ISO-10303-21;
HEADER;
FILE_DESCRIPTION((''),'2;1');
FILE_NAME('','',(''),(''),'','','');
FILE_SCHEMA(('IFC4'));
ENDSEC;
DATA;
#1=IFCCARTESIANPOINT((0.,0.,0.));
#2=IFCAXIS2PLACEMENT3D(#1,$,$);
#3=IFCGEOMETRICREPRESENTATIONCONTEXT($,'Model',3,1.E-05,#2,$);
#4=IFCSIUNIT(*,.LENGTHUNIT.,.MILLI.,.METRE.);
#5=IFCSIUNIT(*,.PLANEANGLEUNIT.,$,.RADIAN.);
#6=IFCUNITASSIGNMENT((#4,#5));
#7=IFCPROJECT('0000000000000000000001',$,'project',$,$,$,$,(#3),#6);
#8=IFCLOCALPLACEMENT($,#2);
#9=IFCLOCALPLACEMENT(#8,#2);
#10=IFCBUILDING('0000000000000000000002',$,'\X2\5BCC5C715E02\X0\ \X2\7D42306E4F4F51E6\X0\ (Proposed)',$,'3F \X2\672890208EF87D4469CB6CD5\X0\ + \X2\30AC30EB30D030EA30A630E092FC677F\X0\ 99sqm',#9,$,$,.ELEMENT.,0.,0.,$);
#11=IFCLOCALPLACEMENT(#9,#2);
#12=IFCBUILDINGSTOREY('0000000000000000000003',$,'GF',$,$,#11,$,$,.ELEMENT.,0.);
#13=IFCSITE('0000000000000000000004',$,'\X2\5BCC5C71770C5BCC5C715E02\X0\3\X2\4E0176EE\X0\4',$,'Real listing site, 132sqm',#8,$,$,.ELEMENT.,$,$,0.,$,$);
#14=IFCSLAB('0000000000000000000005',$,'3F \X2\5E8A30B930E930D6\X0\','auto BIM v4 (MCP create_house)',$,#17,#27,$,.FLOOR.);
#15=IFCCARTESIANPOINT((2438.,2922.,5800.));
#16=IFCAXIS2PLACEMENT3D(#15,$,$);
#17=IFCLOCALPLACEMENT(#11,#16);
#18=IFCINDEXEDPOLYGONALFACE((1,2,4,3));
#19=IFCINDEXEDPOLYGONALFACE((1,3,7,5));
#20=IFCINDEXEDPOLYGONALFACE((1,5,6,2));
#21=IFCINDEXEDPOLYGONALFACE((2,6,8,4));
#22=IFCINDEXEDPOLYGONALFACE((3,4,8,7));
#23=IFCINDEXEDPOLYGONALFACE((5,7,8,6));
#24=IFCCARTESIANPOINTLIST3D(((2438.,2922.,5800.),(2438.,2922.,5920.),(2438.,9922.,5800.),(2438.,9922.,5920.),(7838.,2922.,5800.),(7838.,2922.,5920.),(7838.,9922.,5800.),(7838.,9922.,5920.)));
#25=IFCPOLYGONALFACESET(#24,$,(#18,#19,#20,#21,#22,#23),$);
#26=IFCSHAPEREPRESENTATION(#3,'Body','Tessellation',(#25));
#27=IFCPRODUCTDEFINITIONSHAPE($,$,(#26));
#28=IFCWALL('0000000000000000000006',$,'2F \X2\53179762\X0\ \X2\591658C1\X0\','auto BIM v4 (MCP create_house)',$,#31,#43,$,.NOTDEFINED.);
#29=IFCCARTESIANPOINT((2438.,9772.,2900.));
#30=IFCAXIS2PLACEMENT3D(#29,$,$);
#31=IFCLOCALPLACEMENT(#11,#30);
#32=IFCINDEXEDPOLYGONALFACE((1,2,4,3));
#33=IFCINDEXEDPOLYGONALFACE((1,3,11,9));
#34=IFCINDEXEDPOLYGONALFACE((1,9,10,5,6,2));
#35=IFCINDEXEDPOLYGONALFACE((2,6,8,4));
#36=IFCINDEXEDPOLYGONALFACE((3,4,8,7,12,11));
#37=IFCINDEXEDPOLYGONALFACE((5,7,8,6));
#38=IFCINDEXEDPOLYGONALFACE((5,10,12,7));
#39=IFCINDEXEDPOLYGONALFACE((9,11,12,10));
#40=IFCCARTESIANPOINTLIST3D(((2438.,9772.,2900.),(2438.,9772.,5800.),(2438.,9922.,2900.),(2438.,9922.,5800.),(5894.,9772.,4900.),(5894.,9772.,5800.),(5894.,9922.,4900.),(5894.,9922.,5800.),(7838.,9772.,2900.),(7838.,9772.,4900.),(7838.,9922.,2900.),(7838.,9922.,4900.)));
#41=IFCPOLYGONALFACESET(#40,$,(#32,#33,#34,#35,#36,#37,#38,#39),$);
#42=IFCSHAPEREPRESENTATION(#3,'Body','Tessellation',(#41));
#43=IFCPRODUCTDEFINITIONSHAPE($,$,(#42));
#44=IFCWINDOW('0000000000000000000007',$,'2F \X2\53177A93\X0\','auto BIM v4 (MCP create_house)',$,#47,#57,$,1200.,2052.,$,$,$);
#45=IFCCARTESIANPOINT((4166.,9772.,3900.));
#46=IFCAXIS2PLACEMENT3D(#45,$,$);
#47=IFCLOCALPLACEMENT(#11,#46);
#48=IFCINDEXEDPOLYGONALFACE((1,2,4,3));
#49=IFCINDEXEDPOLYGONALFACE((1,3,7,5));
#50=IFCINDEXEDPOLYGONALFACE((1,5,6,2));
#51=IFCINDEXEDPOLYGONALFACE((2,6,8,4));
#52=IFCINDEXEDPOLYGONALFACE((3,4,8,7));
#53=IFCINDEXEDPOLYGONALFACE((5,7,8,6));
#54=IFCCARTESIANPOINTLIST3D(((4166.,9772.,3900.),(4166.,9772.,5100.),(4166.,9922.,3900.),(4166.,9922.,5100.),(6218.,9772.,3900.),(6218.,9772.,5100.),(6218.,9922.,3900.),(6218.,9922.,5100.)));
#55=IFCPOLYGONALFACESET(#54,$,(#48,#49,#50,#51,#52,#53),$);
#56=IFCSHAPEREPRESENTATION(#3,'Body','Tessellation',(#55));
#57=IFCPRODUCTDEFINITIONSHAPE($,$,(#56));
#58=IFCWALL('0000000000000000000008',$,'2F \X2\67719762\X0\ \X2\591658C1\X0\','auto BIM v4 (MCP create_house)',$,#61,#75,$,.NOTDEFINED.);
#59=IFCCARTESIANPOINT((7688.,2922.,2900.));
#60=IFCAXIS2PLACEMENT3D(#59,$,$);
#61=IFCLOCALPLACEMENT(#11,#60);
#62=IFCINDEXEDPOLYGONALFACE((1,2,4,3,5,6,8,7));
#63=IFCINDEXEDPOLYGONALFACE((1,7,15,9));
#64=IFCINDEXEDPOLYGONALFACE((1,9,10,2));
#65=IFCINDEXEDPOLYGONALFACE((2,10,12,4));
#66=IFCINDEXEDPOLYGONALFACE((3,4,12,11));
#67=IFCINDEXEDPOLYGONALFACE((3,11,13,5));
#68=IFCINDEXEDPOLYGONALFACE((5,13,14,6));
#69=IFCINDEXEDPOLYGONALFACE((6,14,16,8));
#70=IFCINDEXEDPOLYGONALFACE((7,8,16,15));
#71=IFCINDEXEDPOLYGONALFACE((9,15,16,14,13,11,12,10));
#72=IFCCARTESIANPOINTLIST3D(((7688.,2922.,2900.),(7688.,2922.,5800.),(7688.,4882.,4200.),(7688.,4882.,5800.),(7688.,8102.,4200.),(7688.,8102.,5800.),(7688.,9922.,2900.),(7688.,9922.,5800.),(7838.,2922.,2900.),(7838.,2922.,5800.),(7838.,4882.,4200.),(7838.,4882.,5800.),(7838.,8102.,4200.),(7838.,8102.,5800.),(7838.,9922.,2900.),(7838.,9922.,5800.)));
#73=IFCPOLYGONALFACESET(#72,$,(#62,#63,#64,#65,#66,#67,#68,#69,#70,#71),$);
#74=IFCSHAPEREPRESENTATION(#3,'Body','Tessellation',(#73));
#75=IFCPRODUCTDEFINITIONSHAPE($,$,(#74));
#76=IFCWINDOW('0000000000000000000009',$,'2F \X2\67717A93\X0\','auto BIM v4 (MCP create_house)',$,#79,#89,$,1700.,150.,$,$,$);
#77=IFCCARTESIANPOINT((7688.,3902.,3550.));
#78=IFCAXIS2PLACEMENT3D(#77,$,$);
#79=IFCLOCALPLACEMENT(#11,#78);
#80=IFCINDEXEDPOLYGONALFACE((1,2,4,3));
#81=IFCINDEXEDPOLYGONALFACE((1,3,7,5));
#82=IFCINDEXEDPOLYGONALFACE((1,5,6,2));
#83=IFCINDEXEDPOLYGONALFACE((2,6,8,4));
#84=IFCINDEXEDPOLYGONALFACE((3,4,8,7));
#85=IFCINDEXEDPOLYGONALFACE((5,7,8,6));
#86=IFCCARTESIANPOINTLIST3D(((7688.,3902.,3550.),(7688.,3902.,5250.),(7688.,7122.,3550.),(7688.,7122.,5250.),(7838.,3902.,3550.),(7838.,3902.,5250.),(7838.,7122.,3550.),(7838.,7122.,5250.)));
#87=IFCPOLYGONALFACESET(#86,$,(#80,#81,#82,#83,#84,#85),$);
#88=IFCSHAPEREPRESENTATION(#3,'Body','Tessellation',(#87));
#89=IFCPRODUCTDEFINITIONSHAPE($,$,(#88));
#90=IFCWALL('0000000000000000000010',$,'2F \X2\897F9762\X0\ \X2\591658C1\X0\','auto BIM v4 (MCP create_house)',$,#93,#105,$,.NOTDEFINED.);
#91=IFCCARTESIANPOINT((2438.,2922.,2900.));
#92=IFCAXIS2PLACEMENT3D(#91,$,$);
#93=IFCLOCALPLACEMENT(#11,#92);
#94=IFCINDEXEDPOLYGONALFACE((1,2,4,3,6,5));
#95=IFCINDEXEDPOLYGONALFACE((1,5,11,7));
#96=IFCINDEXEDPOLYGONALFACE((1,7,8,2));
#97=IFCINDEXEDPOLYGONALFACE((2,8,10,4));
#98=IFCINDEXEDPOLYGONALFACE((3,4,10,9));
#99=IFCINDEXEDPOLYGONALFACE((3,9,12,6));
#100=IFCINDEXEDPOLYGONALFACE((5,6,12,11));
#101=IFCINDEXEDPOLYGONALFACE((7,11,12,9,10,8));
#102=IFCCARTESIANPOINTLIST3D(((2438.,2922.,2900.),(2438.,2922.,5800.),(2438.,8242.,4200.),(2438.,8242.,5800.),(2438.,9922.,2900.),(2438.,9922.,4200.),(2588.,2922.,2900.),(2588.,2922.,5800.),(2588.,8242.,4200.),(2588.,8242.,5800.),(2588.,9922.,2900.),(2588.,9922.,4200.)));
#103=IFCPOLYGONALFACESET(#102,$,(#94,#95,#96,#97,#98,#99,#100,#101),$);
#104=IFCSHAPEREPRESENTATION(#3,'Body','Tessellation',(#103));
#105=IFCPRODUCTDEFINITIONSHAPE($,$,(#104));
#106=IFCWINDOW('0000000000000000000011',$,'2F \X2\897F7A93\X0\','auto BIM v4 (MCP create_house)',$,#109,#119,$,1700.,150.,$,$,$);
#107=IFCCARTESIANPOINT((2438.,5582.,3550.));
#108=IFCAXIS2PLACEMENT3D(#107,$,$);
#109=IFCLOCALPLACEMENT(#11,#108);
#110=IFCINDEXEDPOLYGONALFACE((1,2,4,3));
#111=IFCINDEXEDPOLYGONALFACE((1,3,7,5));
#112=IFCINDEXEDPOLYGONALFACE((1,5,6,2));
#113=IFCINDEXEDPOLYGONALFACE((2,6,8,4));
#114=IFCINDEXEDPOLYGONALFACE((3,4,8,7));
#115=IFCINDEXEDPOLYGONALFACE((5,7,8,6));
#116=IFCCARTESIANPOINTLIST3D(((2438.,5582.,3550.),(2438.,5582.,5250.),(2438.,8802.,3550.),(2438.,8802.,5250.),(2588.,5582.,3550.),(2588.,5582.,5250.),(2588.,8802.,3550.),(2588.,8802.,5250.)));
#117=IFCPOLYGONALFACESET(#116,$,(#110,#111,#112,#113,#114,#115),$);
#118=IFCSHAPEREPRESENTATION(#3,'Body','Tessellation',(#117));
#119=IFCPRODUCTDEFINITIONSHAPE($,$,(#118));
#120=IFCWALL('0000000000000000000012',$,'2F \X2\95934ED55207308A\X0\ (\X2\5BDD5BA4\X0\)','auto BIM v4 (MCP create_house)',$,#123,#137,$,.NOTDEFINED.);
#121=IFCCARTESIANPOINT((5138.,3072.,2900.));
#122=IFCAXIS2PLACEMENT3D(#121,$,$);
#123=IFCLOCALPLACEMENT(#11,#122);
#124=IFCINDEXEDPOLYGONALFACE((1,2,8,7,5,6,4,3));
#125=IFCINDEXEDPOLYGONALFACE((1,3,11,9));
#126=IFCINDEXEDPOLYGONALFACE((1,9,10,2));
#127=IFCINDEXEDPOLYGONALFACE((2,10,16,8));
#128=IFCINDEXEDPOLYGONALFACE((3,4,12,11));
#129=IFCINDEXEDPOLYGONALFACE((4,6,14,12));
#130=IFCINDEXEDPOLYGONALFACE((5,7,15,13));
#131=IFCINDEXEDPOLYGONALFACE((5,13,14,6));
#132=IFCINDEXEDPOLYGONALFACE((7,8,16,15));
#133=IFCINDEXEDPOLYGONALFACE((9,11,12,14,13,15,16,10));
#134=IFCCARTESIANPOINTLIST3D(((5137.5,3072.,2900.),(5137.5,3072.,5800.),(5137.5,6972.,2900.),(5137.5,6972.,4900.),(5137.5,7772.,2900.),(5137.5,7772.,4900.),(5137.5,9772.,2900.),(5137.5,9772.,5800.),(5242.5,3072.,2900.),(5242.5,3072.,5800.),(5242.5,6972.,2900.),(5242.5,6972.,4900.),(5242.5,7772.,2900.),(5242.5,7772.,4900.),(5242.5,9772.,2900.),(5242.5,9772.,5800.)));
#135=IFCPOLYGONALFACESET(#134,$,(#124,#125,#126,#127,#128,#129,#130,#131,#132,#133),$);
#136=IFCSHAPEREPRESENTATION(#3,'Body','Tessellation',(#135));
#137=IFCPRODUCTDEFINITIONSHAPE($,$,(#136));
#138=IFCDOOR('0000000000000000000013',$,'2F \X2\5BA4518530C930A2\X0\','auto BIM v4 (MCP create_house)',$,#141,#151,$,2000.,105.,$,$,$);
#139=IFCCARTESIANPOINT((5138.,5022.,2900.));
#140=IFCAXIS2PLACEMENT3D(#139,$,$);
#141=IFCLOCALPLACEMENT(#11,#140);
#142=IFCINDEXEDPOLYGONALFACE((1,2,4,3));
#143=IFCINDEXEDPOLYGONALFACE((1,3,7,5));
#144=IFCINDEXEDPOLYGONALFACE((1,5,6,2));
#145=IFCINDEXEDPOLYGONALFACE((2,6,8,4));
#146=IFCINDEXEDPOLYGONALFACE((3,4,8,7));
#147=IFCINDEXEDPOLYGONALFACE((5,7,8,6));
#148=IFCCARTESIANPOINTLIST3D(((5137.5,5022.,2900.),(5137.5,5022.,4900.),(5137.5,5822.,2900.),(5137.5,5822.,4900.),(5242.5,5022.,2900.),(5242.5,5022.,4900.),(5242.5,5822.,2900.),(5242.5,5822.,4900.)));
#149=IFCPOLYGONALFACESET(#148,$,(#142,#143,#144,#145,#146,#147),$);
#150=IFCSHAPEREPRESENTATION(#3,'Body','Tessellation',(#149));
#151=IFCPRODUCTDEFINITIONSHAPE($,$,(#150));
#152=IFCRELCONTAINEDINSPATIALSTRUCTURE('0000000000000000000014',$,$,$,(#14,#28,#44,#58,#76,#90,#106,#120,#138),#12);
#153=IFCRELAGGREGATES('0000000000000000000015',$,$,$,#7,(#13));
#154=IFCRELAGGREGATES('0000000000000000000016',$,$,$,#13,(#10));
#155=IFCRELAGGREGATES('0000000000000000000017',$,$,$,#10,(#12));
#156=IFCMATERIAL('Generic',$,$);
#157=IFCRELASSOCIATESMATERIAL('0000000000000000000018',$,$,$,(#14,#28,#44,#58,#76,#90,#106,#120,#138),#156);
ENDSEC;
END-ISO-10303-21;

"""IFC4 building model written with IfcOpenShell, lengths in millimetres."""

from ifc_helpers import new_model, si_unit, frame, frame_2d, origin, place, context, project, spatial, rectangle, extrude, material, element, fill, save


model = new_model("IFC4")

# Units and contexts
model_context = context("Model", 3, precision=1e-05, world=origin())
ifc_project = project(units=[si_unit("LENGTHUNIT", "METRE", prefix="MILLI"), si_unit("PLANEANGLEUNIT", "RADIAN")], contexts=[model_context])

# Site, building, storey
site_placement = place(None, origin())
site = spatial("IfcSite", under=ifc_project, at=site_placement, Name="富山県富山市3丁目4", ObjectType="Real listing site, 132sqm", CompositionType="ELEMENT", RefElevation=0.0)
building_placement = place(site_placement, origin())
building = spatial("IfcBuilding", under=site, at=building_placement, Name="富山市 終の住処 (Proposed)", ObjectType="3F 木造軸組構法 + ガルバリウム鋼板 99sqm", CompositionType="ELEMENT", ElevationOfRefHeight=0.0, ElevationOfTerrain=0.0)
storey_placement = place(building_placement, origin())
storey = spatial("IfcBuildingStorey", under=building, at=storey_placement, Name="GF", CompositionType="ELEMENT", Elevation=0.0)

# Slab
ifc_material = material(Name="Generic")
slab_placement = place(storey_placement, frame((2438.0, 2922.0, 5800.0)))
element("IfcSlab", 1, at=slab_placement, inside=storey, material=ifc_material, Name="3F 床スラブ", Description="auto BIM v4 (MCP create_house)", PredefinedType="FLOOR", context=model_context, shape_type="SweptSolid", body=[
    extrude(rectangle(XDim=5400.0, YDim=7000.0, at=frame_2d((2700.0, 3500.0))), frame((2438.0, 2922.0, 5800.0)), (0.0, 0.0, 1.0), 120.0),
])

# Walls, openings, windows
wall_1_placement = place(storey_placement, frame((2438.0, 9772.0, 2900.0)))
wall_1 = element("IfcWall", 2, at=wall_1_placement, inside=storey, material=ifc_material, Name="2F 北面 外壁", Description="auto BIM v4 (MCP create_house)", PredefinedType="NOTDEFINED", context=model_context, shape_type="SweptSolid", body=[
    extrude(rectangle(XDim=5400.0, YDim=150.0, at=frame_2d((2700.0, 75.0))), frame((2438.0, 9772.0, 2900.0)), (0.0, 0.0, 1.0), 2900.0),
])
opening_1_placement = place(storey_placement, frame((4166.0, 9772.0, 3900.0)))
opening_1 = element("IfcOpeningElement", 3, at=opening_1_placement, cuts=wall_1, PredefinedType="NOTDEFINED", context=model_context, shape_type="SweptSolid", body=[
    extrude(rectangle(XDim=2052.0, YDim=150.0, at=frame_2d((1026.0, 75.0))), frame((4166.0, 9772.0, 3900.0)), (0.0, 0.0, 1.0), 1200.0),
])
window_1_placement = place(storey_placement, frame((4166.0, 9772.0, 3900.0)))
window_1 = element("IfcWindow", 4, at=window_1_placement, inside=storey, material=ifc_material, Name="2F 北窓", Description="auto BIM v4 (MCP create_house)", OverallHeight=1200.0, OverallWidth=2052.0, context=model_context, shape_type="SweptSolid", body=[
    extrude(rectangle(XDim=2052.0, YDim=150.0, at=frame_2d((1026.0, 75.0))), frame((4166.0, 9772.0, 3900.0)), (0.0, 0.0, 1.0), 1200.0),
])
fill(opening_1, window_1)
wall_2_placement = place(storey_placement, frame((7688.0, 2922.0, 2900.0)))
wall_2 = element("IfcWall", 5, at=wall_2_placement, inside=storey, material=ifc_material, Name="2F 東面 外壁", Description="auto BIM v4 (MCP create_house)", PredefinedType="NOTDEFINED", context=model_context, shape_type="SweptSolid", body=[
    extrude(rectangle(XDim=150.0, YDim=7000.0, at=frame_2d((75.0, 3500.0))), frame((7688.0, 2922.0, 2900.0)), (0.0, 0.0, 1.0), 2900.0),
])
opening_2_placement = place(storey_placement, frame((7688.0, 3902.0, 3550.0)))
opening_2 = element("IfcOpeningElement", 6, at=opening_2_placement, cuts=wall_2, PredefinedType="NOTDEFINED", context=model_context, shape_type="SweptSolid", body=[
    extrude(rectangle(XDim=150.0, YDim=3220.0, at=frame_2d((75.0, 1610.0))), frame((7688.0, 3902.0, 3550.0)), (0.0, 0.0, 1.0), 1700.0),
])
window_2_placement = place(storey_placement, frame((7688.0, 3902.0, 3550.0)))
window_2 = element("IfcWindow", 7, at=window_2_placement, inside=storey, material=ifc_material, Name="2F 東窓", Description="auto BIM v4 (MCP create_house)", OverallHeight=1700.0, OverallWidth=150.0, context=model_context, shape_type="SweptSolid", body=[
    extrude(rectangle(XDim=150.0, YDim=3220.0, at=frame_2d((75.0, 1610.0))), frame((7688.0, 3902.0, 3550.0)), (0.0, 0.0, 1.0), 1700.0),
])
fill(opening_2, window_2)
wall_3_placement = place(storey_placement, frame((2438.0, 2922.0, 2900.0)))
wall_3 = element("IfcWall", 8, at=wall_3_placement, inside=storey, material=ifc_material, Name="2F 西面 外壁", Description="auto BIM v4 (MCP create_house)", PredefinedType="NOTDEFINED", context=model_context, shape_type="SweptSolid", body=[
    extrude(rectangle(XDim=150.0, YDim=7000.0, at=frame_2d((75.0, 3500.0))), frame((2438.0, 2922.0, 2900.0)), (0.0, 0.0, 1.0), 2900.0),
])
opening_3_placement = place(storey_placement, frame((2438.0, 5582.0, 3550.0)))
opening_3 = element("IfcOpeningElement", 9, at=opening_3_placement, cuts=wall_3, PredefinedType="NOTDEFINED", context=model_context, shape_type="SweptSolid", body=[
    extrude(rectangle(XDim=150.0, YDim=3220.0, at=frame_2d((75.0, 1610.0))), frame((2438.0, 5582.0, 3550.0)), (0.0, 0.0, 1.0), 1700.0),
])
window_3_placement = place(storey_placement, frame((2438.0, 5582.0, 3550.0)))
window_3 = element("IfcWindow", 10, at=window_3_placement, inside=storey, material=ifc_material, Name="2F 西窓", Description="auto BIM v4 (MCP create_house)", OverallHeight=1700.0, OverallWidth=150.0, context=model_context, shape_type="SweptSolid", body=[
    extrude(rectangle(XDim=150.0, YDim=3220.0, at=frame_2d((75.0, 1610.0))), frame((2438.0, 5582.0, 3550.0)), (0.0, 0.0, 1.0), 1700.0),
])
fill(opening_3, window_3)

# Wall, opening, door
wall_4_placement = place(storey_placement, frame((5138.0, 3072.0, 2900.0)))
wall_4 = element("IfcWall", 11, at=wall_4_placement, inside=storey, material=ifc_material, Name="2F 間仕切り (寝室)", Description="auto BIM v4 (MCP create_house)", PredefinedType="NOTDEFINED", context=model_context, shape_type="SweptSolid", body=[
    extrude(rectangle(XDim=105.0, YDim=6700.0, at=frame_2d((52.0, 3350.0))), frame((5138.0, 3072.0, 2900.0)), (0.0, 0.0, 1.0), 2900.0),
])
opening_4_placement = place(storey_placement, frame((5138.0, 5022.0, 2900.0)))
opening_4 = element("IfcOpeningElement", 12, at=opening_4_placement, cuts=wall_4, PredefinedType="NOTDEFINED", context=model_context, shape_type="SweptSolid", body=[
    extrude(rectangle(XDim=105.0, YDim=800.0, at=frame_2d((52.0, 400.0))), frame((5138.0, 5022.0, 2900.0)), (0.0, 0.0, 1.0), 2000.0),
])
door_1_placement = place(storey_placement, frame((5138.0, 5022.0, 2900.0)))
door_1 = element("IfcDoor", 13, at=door_1_placement, inside=storey, material=ifc_material, Name="2F 室内ドア", Description="auto BIM v4 (MCP create_house)", OverallHeight=2000.0, OverallWidth=105.0, context=model_context, shape_type="SweptSolid", body=[
    extrude(rectangle(XDim=105.0, YDim=800.0, at=frame_2d((52.0, 400.0))), frame((5138.0, 5022.0, 2900.0)), (0.0, 0.0, 1.0), 2000.0),
])
fill(opening_4, door_1)

save(model, "model.ifc")
